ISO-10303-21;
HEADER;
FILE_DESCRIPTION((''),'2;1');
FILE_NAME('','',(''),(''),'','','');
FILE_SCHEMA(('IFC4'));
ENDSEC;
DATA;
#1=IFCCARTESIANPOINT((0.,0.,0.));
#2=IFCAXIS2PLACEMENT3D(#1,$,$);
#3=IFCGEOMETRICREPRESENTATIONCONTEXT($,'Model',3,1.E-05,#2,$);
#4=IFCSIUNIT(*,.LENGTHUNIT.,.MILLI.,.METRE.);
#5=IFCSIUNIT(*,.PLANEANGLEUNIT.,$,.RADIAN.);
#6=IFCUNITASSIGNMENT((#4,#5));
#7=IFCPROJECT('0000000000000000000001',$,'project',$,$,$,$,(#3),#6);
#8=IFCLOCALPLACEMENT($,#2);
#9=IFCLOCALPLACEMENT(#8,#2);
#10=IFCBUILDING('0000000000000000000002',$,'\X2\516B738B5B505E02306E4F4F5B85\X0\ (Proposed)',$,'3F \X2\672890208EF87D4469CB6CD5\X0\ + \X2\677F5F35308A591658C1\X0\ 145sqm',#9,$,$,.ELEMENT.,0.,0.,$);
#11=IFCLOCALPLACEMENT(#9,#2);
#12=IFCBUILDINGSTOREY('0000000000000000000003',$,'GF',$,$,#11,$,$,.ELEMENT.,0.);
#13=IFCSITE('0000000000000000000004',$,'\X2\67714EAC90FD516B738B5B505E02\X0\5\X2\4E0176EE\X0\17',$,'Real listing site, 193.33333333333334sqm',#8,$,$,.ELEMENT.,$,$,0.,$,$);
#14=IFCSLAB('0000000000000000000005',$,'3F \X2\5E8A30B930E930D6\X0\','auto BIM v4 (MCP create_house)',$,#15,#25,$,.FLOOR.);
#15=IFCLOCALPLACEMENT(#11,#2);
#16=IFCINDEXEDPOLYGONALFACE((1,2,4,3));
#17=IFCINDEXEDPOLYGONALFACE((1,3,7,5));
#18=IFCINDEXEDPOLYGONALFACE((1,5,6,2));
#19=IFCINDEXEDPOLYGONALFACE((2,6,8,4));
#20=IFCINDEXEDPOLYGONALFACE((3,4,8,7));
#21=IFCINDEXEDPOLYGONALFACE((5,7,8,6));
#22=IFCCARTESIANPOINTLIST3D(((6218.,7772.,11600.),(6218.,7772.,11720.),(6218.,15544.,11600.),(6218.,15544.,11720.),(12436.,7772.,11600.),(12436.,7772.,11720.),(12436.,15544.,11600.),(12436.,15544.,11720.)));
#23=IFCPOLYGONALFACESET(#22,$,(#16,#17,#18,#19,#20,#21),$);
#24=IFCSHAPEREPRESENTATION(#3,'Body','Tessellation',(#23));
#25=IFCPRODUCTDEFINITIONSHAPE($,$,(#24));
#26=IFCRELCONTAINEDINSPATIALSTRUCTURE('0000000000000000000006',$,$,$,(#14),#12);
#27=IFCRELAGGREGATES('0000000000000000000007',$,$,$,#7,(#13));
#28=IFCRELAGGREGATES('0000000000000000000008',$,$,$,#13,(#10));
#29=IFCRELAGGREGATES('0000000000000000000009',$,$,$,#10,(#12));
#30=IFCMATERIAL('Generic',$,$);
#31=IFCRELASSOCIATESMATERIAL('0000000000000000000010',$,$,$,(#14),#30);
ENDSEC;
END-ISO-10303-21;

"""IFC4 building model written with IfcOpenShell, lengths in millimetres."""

from ifc_helpers import new_model, si_unit, frame, frame_2d, origin, place, context, project, spatial, rectangle, extrude, material, element, save


model = new_model("IFC4")

# Units and contexts
model_context = context("Model", 3, precision=1e-05, world=origin())
ifc_project = project(units=[si_unit("LENGTHUNIT", "METRE", prefix="MILLI"), si_unit("PLANEANGLEUNIT", "RADIAN")], contexts=[model_context])

# Site, building, storey
site_placement = place(None, origin())
site = spatial("IfcSite", under=ifc_project, at=site_placement, Name="東京都八王子市5丁目17", ObjectType="Real listing site, 193.33333333333334sqm", CompositionType="ELEMENT", RefElevation=0.0)
building_placement = place(site_placement, origin())
building = spatial("IfcBuilding", under=site, at=building_placement, Name="八王子市の住宅 (Proposed)", ObjectType="3F 木造軸組構法 + 板張り外壁 145sqm", CompositionType="ELEMENT", ElevationOfRefHeight=0.0, ElevationOfTerrain=0.0)
storey_placement = place(building_placement, origin())
storey = spatial("IfcBuildingStorey", under=building, at=storey_placement, Name="GF", CompositionType="ELEMENT", Elevation=0.0)

# Slab
ifc_material = material(Name="Generic")
slab_placement = place(storey_placement, frame((3109.0, 3886.0, 5800.0)))
element("IfcSlab", 1, at=slab_placement, inside=storey, material=ifc_material, Name="3F 床スラブ", Description="auto BIM v4 (MCP create_house)", PredefinedType="FLOOR", context=model_context, shape_type="SweptSolid", body=[
    extrude(rectangle(XDim=6218.0, YDim=7772.0, at=frame_2d((3109.0, 3886.0))), frame((3109.0, 3886.0, 5800.0)), (0.0, 0.0, 1.0), 120.0),
])

save(model, "model.ifc")
